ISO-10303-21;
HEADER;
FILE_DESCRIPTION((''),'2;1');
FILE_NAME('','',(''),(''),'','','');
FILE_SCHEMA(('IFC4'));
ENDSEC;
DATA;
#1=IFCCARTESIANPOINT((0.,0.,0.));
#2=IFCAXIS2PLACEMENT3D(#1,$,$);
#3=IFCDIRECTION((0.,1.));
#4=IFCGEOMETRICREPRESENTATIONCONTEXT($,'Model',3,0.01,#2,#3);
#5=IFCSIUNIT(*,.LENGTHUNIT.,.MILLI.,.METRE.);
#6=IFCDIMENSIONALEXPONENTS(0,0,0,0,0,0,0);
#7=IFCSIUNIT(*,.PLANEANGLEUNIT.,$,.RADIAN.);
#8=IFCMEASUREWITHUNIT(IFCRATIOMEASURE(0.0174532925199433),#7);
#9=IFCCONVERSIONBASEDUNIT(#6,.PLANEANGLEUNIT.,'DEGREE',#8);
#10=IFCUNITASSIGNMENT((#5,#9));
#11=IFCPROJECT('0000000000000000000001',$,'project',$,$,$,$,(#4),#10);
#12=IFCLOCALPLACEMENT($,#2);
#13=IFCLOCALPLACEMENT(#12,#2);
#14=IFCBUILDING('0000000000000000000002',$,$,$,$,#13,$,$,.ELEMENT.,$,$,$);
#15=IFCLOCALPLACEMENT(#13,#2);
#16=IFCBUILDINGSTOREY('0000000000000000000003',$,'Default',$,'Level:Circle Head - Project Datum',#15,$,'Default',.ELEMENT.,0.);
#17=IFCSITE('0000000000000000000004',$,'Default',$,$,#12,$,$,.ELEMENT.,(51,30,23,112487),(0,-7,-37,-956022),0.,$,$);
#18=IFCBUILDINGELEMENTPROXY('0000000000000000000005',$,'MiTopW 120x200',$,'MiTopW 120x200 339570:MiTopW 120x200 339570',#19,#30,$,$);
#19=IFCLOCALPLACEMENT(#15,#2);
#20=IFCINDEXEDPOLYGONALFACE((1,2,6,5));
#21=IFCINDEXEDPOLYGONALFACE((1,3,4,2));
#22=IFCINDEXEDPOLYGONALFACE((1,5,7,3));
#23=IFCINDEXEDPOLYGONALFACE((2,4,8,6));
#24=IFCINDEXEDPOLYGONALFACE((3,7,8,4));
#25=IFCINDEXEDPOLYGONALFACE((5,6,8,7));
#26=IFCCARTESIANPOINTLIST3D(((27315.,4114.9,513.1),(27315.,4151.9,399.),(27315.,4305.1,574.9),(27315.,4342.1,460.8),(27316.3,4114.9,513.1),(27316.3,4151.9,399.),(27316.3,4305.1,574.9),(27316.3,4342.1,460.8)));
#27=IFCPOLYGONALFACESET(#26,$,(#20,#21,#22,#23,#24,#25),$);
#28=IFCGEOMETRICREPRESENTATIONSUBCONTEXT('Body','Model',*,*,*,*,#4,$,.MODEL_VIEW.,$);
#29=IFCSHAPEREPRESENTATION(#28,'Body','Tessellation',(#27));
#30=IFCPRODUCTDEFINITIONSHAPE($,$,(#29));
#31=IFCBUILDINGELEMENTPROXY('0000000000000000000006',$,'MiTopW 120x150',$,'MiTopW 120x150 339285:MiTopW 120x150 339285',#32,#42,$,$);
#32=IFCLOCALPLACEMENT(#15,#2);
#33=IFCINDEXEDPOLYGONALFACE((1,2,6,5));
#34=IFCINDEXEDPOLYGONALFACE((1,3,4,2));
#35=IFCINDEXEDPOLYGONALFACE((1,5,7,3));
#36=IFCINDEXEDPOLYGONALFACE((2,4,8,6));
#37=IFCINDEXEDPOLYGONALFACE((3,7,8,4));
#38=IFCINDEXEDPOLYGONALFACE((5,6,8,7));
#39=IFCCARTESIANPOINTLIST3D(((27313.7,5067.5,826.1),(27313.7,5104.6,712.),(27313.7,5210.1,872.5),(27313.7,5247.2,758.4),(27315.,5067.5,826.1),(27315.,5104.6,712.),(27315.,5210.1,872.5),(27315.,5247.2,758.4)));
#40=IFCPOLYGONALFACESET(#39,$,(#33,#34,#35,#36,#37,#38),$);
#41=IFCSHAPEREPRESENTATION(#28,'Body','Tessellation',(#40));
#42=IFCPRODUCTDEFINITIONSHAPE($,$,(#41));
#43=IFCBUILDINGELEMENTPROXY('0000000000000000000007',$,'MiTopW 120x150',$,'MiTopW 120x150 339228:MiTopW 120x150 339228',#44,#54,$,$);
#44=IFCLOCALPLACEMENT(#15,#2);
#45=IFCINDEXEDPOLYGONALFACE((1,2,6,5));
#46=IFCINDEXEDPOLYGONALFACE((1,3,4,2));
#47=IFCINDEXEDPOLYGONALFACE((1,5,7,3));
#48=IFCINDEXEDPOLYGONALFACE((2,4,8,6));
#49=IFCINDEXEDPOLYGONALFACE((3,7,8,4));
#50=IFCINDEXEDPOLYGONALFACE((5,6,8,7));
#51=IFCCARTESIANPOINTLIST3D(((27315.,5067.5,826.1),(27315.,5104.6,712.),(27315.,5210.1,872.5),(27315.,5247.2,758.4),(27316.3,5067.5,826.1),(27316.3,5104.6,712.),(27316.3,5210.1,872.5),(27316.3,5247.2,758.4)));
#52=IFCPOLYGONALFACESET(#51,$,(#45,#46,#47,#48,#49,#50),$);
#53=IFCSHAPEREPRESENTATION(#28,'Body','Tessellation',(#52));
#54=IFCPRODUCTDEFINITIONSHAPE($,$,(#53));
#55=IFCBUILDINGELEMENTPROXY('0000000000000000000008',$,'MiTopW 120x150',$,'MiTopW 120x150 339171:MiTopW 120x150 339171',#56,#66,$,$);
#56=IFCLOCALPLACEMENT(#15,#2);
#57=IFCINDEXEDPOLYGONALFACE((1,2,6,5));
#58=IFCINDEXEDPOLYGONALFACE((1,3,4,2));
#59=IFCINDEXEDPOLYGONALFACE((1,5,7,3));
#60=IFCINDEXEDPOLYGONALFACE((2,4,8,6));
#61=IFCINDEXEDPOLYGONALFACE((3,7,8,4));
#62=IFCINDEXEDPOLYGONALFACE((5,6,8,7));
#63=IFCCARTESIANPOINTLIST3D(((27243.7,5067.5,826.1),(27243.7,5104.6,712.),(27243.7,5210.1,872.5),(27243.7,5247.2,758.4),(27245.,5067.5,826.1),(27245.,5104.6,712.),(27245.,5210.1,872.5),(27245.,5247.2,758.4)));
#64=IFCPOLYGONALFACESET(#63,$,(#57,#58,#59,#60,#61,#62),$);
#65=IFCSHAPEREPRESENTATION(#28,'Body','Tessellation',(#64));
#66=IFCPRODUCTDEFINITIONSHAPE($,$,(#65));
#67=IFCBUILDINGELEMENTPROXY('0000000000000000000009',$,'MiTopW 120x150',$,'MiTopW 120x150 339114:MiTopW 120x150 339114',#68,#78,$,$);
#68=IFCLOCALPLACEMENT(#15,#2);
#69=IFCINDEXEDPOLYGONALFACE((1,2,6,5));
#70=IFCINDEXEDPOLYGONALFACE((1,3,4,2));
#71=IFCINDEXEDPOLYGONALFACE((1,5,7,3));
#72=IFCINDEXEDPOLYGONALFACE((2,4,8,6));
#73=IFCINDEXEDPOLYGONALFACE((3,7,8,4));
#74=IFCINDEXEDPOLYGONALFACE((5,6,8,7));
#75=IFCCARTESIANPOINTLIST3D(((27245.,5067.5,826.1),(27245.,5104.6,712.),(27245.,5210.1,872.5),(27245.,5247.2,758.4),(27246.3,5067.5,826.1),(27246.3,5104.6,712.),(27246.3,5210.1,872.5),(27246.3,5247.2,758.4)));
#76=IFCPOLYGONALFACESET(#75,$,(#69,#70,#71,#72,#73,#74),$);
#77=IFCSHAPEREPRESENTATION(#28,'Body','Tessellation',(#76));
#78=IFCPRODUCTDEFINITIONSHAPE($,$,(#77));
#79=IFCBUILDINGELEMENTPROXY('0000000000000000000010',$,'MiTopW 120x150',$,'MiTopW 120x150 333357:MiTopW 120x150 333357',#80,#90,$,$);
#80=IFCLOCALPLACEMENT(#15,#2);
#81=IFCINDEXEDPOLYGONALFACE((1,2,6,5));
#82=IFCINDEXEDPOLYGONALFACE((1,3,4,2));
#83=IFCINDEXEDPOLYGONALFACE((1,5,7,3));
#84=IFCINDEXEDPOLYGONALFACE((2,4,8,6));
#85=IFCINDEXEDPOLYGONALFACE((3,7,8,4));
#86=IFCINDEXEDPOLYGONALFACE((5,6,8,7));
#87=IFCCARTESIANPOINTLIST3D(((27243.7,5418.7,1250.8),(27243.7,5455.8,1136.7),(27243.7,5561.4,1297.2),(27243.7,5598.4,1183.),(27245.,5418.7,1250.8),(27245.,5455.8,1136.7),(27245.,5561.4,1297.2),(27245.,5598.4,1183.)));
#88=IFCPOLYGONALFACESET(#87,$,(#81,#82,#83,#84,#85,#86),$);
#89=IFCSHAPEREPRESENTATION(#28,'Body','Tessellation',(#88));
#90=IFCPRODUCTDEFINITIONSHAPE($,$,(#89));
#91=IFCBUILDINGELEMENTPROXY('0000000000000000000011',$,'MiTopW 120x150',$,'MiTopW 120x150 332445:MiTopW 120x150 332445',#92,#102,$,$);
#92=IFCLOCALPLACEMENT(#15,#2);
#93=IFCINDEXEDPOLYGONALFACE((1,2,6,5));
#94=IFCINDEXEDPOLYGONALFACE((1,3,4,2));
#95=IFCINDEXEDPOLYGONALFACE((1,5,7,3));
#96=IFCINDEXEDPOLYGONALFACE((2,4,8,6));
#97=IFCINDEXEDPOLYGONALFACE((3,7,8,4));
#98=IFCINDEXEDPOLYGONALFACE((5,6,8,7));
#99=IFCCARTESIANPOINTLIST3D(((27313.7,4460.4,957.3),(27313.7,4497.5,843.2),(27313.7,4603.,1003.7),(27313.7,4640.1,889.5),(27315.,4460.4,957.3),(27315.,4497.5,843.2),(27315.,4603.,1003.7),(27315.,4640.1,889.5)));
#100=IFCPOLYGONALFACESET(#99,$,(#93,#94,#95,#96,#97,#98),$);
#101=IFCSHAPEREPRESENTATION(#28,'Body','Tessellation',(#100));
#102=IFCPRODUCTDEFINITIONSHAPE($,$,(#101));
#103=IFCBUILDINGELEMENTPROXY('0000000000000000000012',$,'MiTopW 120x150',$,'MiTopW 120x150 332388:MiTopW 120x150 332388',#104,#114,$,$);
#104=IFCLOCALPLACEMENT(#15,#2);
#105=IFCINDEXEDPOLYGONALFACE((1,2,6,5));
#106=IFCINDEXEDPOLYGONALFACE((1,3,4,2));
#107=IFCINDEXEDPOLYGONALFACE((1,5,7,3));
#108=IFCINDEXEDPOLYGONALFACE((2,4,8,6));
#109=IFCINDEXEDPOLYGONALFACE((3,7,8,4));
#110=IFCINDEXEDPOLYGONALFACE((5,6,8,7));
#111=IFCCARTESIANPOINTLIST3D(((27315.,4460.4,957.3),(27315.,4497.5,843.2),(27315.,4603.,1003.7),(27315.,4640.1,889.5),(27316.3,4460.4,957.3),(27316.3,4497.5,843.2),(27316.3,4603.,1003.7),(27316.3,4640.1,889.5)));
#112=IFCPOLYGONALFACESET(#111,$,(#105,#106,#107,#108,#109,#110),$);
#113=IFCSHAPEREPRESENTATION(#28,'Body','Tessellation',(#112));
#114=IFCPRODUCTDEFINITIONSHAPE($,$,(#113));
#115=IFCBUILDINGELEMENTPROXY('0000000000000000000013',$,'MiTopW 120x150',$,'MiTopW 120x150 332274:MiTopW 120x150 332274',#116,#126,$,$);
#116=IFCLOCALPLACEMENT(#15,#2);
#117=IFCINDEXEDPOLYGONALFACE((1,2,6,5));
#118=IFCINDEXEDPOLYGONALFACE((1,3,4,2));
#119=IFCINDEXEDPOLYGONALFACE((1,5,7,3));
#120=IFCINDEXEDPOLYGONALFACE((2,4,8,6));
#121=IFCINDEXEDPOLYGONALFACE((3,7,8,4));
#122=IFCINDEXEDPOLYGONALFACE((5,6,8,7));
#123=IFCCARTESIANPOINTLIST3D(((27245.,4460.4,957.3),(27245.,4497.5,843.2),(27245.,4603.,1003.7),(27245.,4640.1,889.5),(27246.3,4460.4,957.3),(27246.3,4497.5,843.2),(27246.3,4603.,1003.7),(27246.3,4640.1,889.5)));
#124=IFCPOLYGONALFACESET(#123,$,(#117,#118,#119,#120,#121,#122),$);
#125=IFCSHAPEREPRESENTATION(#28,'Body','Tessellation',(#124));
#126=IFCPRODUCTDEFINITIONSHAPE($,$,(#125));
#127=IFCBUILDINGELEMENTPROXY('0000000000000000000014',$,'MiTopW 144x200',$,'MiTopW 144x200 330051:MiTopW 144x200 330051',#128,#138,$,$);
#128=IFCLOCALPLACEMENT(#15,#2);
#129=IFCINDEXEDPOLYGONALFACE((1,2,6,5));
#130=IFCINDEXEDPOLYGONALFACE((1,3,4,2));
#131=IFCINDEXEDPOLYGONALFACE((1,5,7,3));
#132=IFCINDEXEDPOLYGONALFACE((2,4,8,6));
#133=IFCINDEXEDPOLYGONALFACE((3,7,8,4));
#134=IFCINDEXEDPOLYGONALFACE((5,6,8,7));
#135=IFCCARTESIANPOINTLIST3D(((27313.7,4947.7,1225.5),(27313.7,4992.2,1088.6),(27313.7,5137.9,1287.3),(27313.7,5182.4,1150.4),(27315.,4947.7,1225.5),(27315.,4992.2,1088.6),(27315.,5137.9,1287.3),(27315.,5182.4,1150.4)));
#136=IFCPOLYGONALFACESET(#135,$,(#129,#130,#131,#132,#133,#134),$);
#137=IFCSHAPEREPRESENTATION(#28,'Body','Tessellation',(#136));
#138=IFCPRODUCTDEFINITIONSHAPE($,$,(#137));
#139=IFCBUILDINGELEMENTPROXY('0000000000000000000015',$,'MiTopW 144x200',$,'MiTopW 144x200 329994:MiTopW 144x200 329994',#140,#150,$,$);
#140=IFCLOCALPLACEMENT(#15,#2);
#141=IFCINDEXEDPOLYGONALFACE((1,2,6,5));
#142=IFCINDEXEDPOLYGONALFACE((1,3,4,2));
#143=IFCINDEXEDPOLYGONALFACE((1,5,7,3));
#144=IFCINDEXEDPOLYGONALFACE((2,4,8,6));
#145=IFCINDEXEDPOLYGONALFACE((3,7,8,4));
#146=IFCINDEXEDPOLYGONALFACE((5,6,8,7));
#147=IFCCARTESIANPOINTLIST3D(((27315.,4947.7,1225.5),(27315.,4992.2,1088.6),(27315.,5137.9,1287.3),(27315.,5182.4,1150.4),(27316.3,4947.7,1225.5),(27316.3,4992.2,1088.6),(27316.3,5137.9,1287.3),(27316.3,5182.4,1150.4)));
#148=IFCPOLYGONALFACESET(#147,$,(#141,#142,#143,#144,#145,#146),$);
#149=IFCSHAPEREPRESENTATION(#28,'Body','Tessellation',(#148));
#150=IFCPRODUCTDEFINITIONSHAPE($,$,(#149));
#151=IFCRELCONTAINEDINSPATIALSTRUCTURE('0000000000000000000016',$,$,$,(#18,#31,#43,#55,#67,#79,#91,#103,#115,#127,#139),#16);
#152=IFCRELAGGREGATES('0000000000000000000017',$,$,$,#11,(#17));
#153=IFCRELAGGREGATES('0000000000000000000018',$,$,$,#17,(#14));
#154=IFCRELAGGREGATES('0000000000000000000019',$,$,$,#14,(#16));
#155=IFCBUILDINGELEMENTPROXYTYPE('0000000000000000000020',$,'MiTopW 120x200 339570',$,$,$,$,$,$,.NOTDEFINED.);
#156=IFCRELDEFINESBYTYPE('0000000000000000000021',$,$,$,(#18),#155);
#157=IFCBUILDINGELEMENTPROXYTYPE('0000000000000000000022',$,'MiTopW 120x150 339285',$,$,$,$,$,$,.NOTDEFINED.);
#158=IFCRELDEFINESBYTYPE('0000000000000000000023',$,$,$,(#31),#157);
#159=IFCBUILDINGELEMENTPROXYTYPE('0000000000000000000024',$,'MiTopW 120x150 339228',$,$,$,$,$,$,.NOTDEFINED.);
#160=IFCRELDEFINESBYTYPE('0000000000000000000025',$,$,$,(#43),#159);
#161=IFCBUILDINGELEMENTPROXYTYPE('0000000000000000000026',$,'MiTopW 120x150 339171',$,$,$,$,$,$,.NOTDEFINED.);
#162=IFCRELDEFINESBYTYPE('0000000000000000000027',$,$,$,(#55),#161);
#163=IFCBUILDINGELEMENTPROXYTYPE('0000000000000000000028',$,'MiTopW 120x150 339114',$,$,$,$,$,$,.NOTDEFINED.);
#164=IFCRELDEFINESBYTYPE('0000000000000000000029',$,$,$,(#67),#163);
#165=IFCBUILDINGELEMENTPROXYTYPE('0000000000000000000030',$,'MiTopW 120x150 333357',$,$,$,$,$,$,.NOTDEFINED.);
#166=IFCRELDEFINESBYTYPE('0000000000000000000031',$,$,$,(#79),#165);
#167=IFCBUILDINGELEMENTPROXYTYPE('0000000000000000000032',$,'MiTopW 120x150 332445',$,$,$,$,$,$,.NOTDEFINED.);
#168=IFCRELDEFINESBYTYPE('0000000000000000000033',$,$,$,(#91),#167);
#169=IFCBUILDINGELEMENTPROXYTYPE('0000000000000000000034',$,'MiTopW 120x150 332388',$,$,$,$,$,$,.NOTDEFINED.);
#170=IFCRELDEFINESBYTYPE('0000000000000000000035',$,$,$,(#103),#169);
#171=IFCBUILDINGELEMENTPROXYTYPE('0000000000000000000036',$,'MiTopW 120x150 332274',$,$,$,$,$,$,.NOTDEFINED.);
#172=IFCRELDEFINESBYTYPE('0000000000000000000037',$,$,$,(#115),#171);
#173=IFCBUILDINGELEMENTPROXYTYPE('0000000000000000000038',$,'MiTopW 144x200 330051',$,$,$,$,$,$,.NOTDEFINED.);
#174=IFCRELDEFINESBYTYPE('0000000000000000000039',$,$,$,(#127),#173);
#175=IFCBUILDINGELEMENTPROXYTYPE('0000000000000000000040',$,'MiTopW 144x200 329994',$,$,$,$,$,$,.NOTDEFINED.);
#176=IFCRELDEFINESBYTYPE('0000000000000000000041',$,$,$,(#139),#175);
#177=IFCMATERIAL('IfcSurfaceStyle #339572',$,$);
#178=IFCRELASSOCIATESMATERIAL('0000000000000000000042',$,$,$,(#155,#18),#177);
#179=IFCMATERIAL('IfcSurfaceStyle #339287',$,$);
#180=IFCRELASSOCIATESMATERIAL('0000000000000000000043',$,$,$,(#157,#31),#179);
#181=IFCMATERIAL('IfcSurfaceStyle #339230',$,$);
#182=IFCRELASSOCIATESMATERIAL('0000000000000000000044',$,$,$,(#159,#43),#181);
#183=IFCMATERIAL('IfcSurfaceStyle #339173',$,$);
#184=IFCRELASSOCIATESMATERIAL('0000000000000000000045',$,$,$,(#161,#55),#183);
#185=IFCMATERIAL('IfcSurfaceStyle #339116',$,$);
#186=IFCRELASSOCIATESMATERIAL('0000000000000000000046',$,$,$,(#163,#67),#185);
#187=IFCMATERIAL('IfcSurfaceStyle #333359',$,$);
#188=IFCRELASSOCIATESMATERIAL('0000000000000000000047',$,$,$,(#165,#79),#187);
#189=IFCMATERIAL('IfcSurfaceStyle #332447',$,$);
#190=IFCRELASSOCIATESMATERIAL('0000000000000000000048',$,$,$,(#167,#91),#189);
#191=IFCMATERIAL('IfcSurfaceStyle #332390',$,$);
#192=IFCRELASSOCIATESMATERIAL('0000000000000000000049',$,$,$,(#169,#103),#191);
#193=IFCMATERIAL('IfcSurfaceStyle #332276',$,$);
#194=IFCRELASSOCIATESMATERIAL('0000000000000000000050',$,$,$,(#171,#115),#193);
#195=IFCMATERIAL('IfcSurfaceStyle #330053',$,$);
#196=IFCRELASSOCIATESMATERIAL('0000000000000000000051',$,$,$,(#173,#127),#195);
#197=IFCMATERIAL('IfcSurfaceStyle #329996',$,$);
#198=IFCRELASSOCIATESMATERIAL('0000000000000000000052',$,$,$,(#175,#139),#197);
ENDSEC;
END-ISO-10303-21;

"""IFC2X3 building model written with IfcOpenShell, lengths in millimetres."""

from ifc_helpers import new_model, entity, si_unit, converted_unit, direction, frame, origin, place, context, subcontext, project, spatial, polyline, outline, extrude, source, transform, mapped, material, type_object, type_shapes, element, save


model = new_model("IFC2X3")

# Units and contexts
model_context = context("Model", 3, precision=0.01, world=origin(), true_north=direction((0.0, 1.0)))
body_context = subcontext(model_context, "Body", "Model", "MODEL_VIEW")
ifc_project = project(units=[si_unit("LENGTHUNIT", "METRE", prefix="MILLI"), converted_unit("PLANEANGLEUNIT", "DEGREE", entity("IfcRatioMeasure", 0.0174532925199433), si_unit("PLANEANGLEUNIT", "RADIAN"), dimensions=[0, 0, 0, 0, 0, 0, 0])], contexts=[model_context])

# Site, building, storey
site_placement = place(None, origin())
site = spatial("IfcSite", under=ifc_project, at=site_placement, Name="Default", CompositionType="ELEMENT", RefLatitude=(51, 30, 23, 112487), RefLongitude=(0, -7, -37, -956022), RefElevation=0.0)
building_placement = place(site_placement, origin())
building = spatial("IfcBuilding", under=site, at=building_placement, CompositionType="ELEMENT")
storey_placement = place(building_placement, origin())
storey = spatial("IfcBuildingStorey", under=building, at=storey_placement, Name="Default", ObjectType="Level:Circle Head - Project Datum", LongName="Default", CompositionType="ELEMENT", Elevation=0.0)

# Building element proxies
ifc_material_1 = material(Name="IfcSurfaceStyle #339572")
building_element_proxy_type_1 = type_object("IfcBuildingElementProxyType", Name="MiTopW 120x200 339570", PredefinedType="NOTDEFINED", material=ifc_material_1)
shared_shape_1 = source(origin(), body_context, "Body", "SweptSolid", [
    extrude(outline(polyline([(-100.0, -60.0), (100.0, -60.0), (100.0, 60.0), (-100.0, 60.0), (-100.0, -60.0)])), frame((100.0, 60.0, 0.0), z_axis=(0.0, 0.0, 1.0), x_axis=(-1.0, 0.0, 0.0)), (0.0, 0.0, 1.0), 1.3),
])
type_shapes(building_element_proxy_type_1, [shared_shape_1])
proxy_1_placement = place(building_placement, frame((27316.3, 4114.9, 513.1), z_axis=(-1.0, 0.0, 0.0), x_axis=(0.0, 0.951057, 0.309017)))
element("IfcBuildingElementProxy", 1, at=proxy_1_placement, inside=storey, type_object=building_element_proxy_type_1, material=ifc_material_1, Name="MiTopW 120x200", ObjectType="MiTopW 120x200 339570:MiTopW 120x200 339570", context=body_context, shape_type="MappedRepresentation", body=[
    mapped(shared_shape_1, transform((0.0, 0.0, 0.0), scale=1.0)),
])
ifc_material_2 = material(Name="IfcSurfaceStyle #339287")
building_element_proxy_type_2 = type_object("IfcBuildingElementProxyType", Name="MiTopW 120x150 339285", PredefinedType="NOTDEFINED", material=ifc_material_2)
shared_shape_2 = source(origin(), body_context, "Body", "SweptSolid", [
    extrude(outline(polyline([(-75.0, -60.0), (75.0, -60.0), (75.0, 60.0), (-75.0, 60.0), (-75.0, -60.0)])), frame((75.0, 60.0, 0.0), z_axis=(0.0, 0.0, 1.0), x_axis=(-1.0, 0.0, 0.0)), (0.0, 0.0, 1.0), 1.3),
])
type_shapes(building_element_proxy_type_2, [shared_shape_2])
proxy_2_placement = place(building_placement, frame((27315.0, 5067.5, 826.1), z_axis=(-1.0, 0.0, 0.0), x_axis=(0.0, 0.951057, 0.309017)))
element("IfcBuildingElementProxy", 2, at=proxy_2_placement, inside=storey, type_object=building_element_proxy_type_2, material=ifc_material_2, Name="MiTopW 120x150", ObjectType="MiTopW 120x150 339285:MiTopW 120x150 339285", context=body_context, shape_type="MappedRepresentation", body=[
    mapped(shared_shape_2, transform((0.0, 0.0, 0.0), scale=1.0)),
])
ifc_material_3 = material(Name="IfcSurfaceStyle #339230")
building_element_proxy_type_3 = type_object("IfcBuildingElementProxyType", Name="MiTopW 120x150 339228", PredefinedType="NOTDEFINED", material=ifc_material_3)
shared_shape_3 = source(origin(), body_context, "Body", "SweptSolid", [
    extrude(outline(polyline([(-75.0, -60.0), (75.0, -60.0), (75.0, 60.0), (-75.0, 60.0), (-75.0, -60.0)])), frame((75.0, 60.0, 0.0), z_axis=(0.0, 0.0, 1.0), x_axis=(-1.0, 0.0, 0.0)), (0.0, 0.0, 1.0), 1.3),
])
type_shapes(building_element_proxy_type_3, [shared_shape_3])
proxy_3_placement = place(building_placement, frame((27316.3, 5067.5, 826.1), z_axis=(-1.0, 0.0, 0.0), x_axis=(0.0, 0.951057, 0.309017)))
element("IfcBuildingElementProxy", 3, at=proxy_3_placement, inside=storey, type_object=building_element_proxy_type_3, material=ifc_material_3, Name="MiTopW 120x150", ObjectType="MiTopW 120x150 339228:MiTopW 120x150 339228", context=body_context, shape_type="MappedRepresentation", body=[
    mapped(shared_shape_3, transform((0.0, 0.0, 0.0), scale=1.0)),
])
ifc_material_4 = material(Name="IfcSurfaceStyle #339173")
building_element_proxy_type_4 = type_object("IfcBuildingElementProxyType", Name="MiTopW 120x150 339171", PredefinedType="NOTDEFINED", material=ifc_material_4)
shared_shape_4 = source(origin(), body_context, "Body", "SweptSolid", [
    extrude(outline(polyline([(-75.0, -60.0), (75.0, -60.0), (75.0, 60.0), (-75.0, 60.0), (-75.0, -60.0)])), frame((75.0, 60.0, 0.0), z_axis=(0.0, 0.0, 1.0), x_axis=(-1.0, 0.0, 0.0)), (0.0, 0.0, 1.0), 1.3),
])
type_shapes(building_element_proxy_type_4, [shared_shape_4])
proxy_4_placement = place(building_placement, frame((27245.0, 5067.5, 826.1), z_axis=(-1.0, 0.0, 0.0), x_axis=(0.0, 0.951057, 0.309017)))
element("IfcBuildingElementProxy", 4, at=proxy_4_placement, inside=storey, type_object=building_element_proxy_type_4, material=ifc_material_4, Name="MiTopW 120x150", ObjectType="MiTopW 120x150 339171:MiTopW 120x150 339171", context=body_context, shape_type="MappedRepresentation", body=[
    mapped(shared_shape_4, transform((0.0, 0.0, 0.0), scale=1.0)),
])
ifc_material_5 = material(Name="IfcSurfaceStyle #339116")
building_element_proxy_type_5 = type_object("IfcBuildingElementProxyType", Name="MiTopW 120x150 339114", PredefinedType="NOTDEFINED", material=ifc_material_5)
shared_shape_5 = source(origin(), body_context, "Body", "SweptSolid", [
    extrude(outline(polyline([(-75.0, -60.0), (75.0, -60.0), (75.0, 60.0), (-75.0, 60.0), (-75.0, -60.0)])), frame((75.0, 60.0, 0.0), z_axis=(0.0, 0.0, 1.0), x_axis=(-1.0, 0.0, 0.0)), (0.0, 0.0, 1.0), 1.3),
])
type_shapes(building_element_proxy_type_5, [shared_shape_5])
proxy_5_placement = place(building_placement, frame((27246.3, 5067.5, 826.1), z_axis=(-1.0, 0.0, 0.0), x_axis=(0.0, 0.951057, 0.309017)))
element("IfcBuildingElementProxy", 5, at=proxy_5_placement, inside=storey, type_object=building_element_proxy_type_5, material=ifc_material_5, Name="MiTopW 120x150", ObjectType="MiTopW 120x150 339114:MiTopW 120x150 339114", context=body_context, shape_type="MappedRepresentation", body=[
    mapped(shared_shape_5, transform((0.0, 0.0, 0.0), scale=1.0)),
])
ifc_material_6 = material(Name="IfcSurfaceStyle #333359")
building_element_proxy_type_6 = type_object("IfcBuildingElementProxyType", Name="MiTopW 120x150 333357", PredefinedType="NOTDEFINED", material=ifc_material_6)
shared_shape_6 = source(origin(), body_context, "Body", "SweptSolid", [
    extrude(outline(polyline([(-75.0, -60.0), (75.0, -60.0), (75.0, 60.0), (-75.0, 60.0), (-75.0, -60.0)])), frame((75.0, 60.0, 0.0), z_axis=(0.0, 0.0, 1.0), x_axis=(-1.0, 0.0, 0.0)), (0.0, 0.0, 1.0), 1.3),
])
type_shapes(building_element_proxy_type_6, [shared_shape_6])
proxy_6_placement = place(building_placement, frame((27245.0, 5418.7, 1250.8), z_axis=(-1.0, 0.0, 0.0), x_axis=(0.0, 0.951057, 0.309017)))
element("IfcBuildingElementProxy", 6, at=proxy_6_placement, inside=storey, type_object=building_element_proxy_type_6, material=ifc_material_6, Name="MiTopW 120x150", ObjectType="MiTopW 120x150 333357:MiTopW 120x150 333357", context=body_context, shape_type="MappedRepresentation", body=[
    mapped(shared_shape_6, transform((0.0, 0.0, 0.0), scale=1.0)),
])
ifc_material_7 = material(Name="IfcSurfaceStyle #332447")
building_element_proxy_type_7 = type_object("IfcBuildingElementProxyType", Name="MiTopW 120x150 332445", PredefinedType="NOTDEFINED", material=ifc_material_7)
shared_shape_7 = source(origin(), body_context, "Body", "SweptSolid", [
    extrude(outline(polyline([(-75.0, -60.0), (75.0, -60.0), (75.0, 60.0), (-75.0, 60.0), (-75.0, -60.0)])), frame((75.0, 60.0, 0.0), z_axis=(0.0, 0.0, 1.0), x_axis=(-1.0, 0.0, 0.0)), (0.0, 0.0, 1.0), 1.3),
])
type_shapes(building_element_proxy_type_7, [shared_shape_7])
proxy_7_placement = place(building_placement, frame((27315.0, 4460.4, 957.3), z_axis=(-1.0, 0.0, 0.0), x_axis=(0.0, 0.951057, 0.309017)))
element("IfcBuildingElementProxy", 7, at=proxy_7_placement, inside=storey, type_object=building_element_proxy_type_7, material=ifc_material_7, Name="MiTopW 120x150", ObjectType="MiTopW 120x150 332445:MiTopW 120x150 332445", context=body_context, shape_type="MappedRepresentation", body=[
    mapped(shared_shape_7, transform((0.0, 0.0, 0.0), scale=1.0)),
])
ifc_material_8 = material(Name="IfcSurfaceStyle #332390")
building_element_proxy_type_8 = type_object("IfcBuildingElementProxyType", Name="MiTopW 120x150 332388", PredefinedType="NOTDEFINED", material=ifc_material_8)
shared_shape_8 = source(origin(), body_context, "Body", "SweptSolid", [
    extrude(outline(polyline([(-75.0, -60.0), (75.0, -60.0), (75.0, 60.0), (-75.0, 60.0), (-75.0, -60.0)])), frame((75.0, 60.0, 0.0), z_axis=(0.0, 0.0, 1.0), x_axis=(-1.0, 0.0, 0.0)), (0.0, 0.0, 1.0), 1.3),
])
type_shapes(building_element_proxy_type_8, [shared_shape_8])
proxy_8_placement = place(building_placement, frame((27316.3, 4460.4, 957.3), z_axis=(-1.0, 0.0, 0.0), x_axis=(0.0, 0.951057, 0.309017)))
element("IfcBuildingElementProxy", 8, at=proxy_8_placement, inside=storey, type_object=building_element_proxy_type_8, material=ifc_material_8, Name="MiTopW 120x150", ObjectType="MiTopW 120x150 332388:MiTopW 120x150 332388", context=body_context, shape_type="MappedRepresentation", body=[
    mapped(shared_shape_8, transform((0.0, 0.0, 0.0), scale=1.0)),
])
ifc_material_9 = material(Name="IfcSurfaceStyle #332276")
building_element_proxy_type_9 = type_object("IfcBuildingElementProxyType", Name="MiTopW 120x150 332274", PredefinedType="NOTDEFINED", material=ifc_material_9)
shared_shape_9 = source(origin(), body_context, "Body", "SweptSolid", [
    extrude(outline(polyline([(-75.0, -60.0), (75.0, -60.0), (75.0, 60.0), (-75.0, 60.0), (-75.0, -60.0)])), frame((75.0, 60.0, 0.0), z_axis=(0.0, 0.0, 1.0), x_axis=(-1.0, 0.0, 0.0)), (0.0, 0.0, 1.0), 1.3),
])
type_shapes(building_element_proxy_type_9, [shared_shape_9])
proxy_9_placement = place(building_placement, frame((27246.3, 4460.4, 957.3), z_axis=(-1.0, 0.0, 0.0), x_axis=(0.0, 0.951057, 0.309017)))
element("IfcBuildingElementProxy", 9, at=proxy_9_placement, inside=storey, type_object=building_element_proxy_type_9, material=ifc_material_9, Name="MiTopW 120x150", ObjectType="MiTopW 120x150 332274:MiTopW 120x150 332274", context=body_context, shape_type="MappedRepresentation", body=[
    mapped(shared_shape_9, transform((0.0, 0.0, 0.0), scale=1.0)),
])
ifc_material_10 = material(Name="IfcSurfaceStyle #330053")
building_element_proxy_type_10 = type_object("IfcBuildingElementProxyType", Name="MiTopW 144x200 330051", PredefinedType="NOTDEFINED", material=ifc_material_10)
shared_shape_10 = source(origin(), body_context, "Body", "SweptSolid", [
    extrude(outline(polyline([(-100.0, -72.0), (100.0, -72.0), (100.0, 72.0), (-100.0, 72.0), (-100.0, -72.0)])), frame((100.0, 72.0, 0.0), z_axis=(0.0, 0.0, 1.0), x_axis=(-1.0, 0.0, 0.0)), (0.0, 0.0, 1.0), 1.3),
])
type_shapes(building_element_proxy_type_10, [shared_shape_10])
proxy_10_placement = place(building_placement, frame((27315.0, 4947.7, 1225.5), z_axis=(-1.0, 0.0, 0.0), x_axis=(0.0, 0.951057, 0.309017)))
element("IfcBuildingElementProxy", 10, at=proxy_10_placement, inside=storey, type_object=building_element_proxy_type_10, material=ifc_material_10, Name="MiTopW 144x200", ObjectType="MiTopW 144x200 330051:MiTopW 144x200 330051", context=body_context, shape_type="MappedRepresentation", body=[
    mapped(shared_shape_10, transform((0.0, 0.0, 0.0), scale=1.0)),
])
ifc_material_11 = material(Name="IfcSurfaceStyle #329996")
building_element_proxy_type_11 = type_object("IfcBuildingElementProxyType", Name="MiTopW 144x200 329994", PredefinedType="NOTDEFINED", material=ifc_material_11)
shared_shape_11 = source(origin(), body_context, "Body", "SweptSolid", [
    extrude(outline(polyline([(-100.0, -72.0), (100.0, -72.0), (100.0, 72.0), (-100.0, 72.0), (-100.0, -72.0)])), frame((100.0, 72.0, 0.0), z_axis=(0.0, 0.0, 1.0), x_axis=(-1.0, 0.0, 0.0)), (0.0, 0.0, 1.0), 1.3),
])
type_shapes(building_element_proxy_type_11, [shared_shape_11])
proxy_11_placement = place(building_placement, frame((27316.3, 4947.7, 1225.5), z_axis=(-1.0, 0.0, 0.0), x_axis=(0.0, 0.951057, 0.309017)))
element("IfcBuildingElementProxy", 11, at=proxy_11_placement, inside=storey, type_object=building_element_proxy_type_11, material=ifc_material_11, Name="MiTopW 144x200", ObjectType="MiTopW 144x200 329994:MiTopW 144x200 329994", context=body_context, shape_type="MappedRepresentation", body=[
    mapped(shared_shape_11, transform((0.0, 0.0, 0.0), scale=1.0)),
])

save(model, "model.ifc")
